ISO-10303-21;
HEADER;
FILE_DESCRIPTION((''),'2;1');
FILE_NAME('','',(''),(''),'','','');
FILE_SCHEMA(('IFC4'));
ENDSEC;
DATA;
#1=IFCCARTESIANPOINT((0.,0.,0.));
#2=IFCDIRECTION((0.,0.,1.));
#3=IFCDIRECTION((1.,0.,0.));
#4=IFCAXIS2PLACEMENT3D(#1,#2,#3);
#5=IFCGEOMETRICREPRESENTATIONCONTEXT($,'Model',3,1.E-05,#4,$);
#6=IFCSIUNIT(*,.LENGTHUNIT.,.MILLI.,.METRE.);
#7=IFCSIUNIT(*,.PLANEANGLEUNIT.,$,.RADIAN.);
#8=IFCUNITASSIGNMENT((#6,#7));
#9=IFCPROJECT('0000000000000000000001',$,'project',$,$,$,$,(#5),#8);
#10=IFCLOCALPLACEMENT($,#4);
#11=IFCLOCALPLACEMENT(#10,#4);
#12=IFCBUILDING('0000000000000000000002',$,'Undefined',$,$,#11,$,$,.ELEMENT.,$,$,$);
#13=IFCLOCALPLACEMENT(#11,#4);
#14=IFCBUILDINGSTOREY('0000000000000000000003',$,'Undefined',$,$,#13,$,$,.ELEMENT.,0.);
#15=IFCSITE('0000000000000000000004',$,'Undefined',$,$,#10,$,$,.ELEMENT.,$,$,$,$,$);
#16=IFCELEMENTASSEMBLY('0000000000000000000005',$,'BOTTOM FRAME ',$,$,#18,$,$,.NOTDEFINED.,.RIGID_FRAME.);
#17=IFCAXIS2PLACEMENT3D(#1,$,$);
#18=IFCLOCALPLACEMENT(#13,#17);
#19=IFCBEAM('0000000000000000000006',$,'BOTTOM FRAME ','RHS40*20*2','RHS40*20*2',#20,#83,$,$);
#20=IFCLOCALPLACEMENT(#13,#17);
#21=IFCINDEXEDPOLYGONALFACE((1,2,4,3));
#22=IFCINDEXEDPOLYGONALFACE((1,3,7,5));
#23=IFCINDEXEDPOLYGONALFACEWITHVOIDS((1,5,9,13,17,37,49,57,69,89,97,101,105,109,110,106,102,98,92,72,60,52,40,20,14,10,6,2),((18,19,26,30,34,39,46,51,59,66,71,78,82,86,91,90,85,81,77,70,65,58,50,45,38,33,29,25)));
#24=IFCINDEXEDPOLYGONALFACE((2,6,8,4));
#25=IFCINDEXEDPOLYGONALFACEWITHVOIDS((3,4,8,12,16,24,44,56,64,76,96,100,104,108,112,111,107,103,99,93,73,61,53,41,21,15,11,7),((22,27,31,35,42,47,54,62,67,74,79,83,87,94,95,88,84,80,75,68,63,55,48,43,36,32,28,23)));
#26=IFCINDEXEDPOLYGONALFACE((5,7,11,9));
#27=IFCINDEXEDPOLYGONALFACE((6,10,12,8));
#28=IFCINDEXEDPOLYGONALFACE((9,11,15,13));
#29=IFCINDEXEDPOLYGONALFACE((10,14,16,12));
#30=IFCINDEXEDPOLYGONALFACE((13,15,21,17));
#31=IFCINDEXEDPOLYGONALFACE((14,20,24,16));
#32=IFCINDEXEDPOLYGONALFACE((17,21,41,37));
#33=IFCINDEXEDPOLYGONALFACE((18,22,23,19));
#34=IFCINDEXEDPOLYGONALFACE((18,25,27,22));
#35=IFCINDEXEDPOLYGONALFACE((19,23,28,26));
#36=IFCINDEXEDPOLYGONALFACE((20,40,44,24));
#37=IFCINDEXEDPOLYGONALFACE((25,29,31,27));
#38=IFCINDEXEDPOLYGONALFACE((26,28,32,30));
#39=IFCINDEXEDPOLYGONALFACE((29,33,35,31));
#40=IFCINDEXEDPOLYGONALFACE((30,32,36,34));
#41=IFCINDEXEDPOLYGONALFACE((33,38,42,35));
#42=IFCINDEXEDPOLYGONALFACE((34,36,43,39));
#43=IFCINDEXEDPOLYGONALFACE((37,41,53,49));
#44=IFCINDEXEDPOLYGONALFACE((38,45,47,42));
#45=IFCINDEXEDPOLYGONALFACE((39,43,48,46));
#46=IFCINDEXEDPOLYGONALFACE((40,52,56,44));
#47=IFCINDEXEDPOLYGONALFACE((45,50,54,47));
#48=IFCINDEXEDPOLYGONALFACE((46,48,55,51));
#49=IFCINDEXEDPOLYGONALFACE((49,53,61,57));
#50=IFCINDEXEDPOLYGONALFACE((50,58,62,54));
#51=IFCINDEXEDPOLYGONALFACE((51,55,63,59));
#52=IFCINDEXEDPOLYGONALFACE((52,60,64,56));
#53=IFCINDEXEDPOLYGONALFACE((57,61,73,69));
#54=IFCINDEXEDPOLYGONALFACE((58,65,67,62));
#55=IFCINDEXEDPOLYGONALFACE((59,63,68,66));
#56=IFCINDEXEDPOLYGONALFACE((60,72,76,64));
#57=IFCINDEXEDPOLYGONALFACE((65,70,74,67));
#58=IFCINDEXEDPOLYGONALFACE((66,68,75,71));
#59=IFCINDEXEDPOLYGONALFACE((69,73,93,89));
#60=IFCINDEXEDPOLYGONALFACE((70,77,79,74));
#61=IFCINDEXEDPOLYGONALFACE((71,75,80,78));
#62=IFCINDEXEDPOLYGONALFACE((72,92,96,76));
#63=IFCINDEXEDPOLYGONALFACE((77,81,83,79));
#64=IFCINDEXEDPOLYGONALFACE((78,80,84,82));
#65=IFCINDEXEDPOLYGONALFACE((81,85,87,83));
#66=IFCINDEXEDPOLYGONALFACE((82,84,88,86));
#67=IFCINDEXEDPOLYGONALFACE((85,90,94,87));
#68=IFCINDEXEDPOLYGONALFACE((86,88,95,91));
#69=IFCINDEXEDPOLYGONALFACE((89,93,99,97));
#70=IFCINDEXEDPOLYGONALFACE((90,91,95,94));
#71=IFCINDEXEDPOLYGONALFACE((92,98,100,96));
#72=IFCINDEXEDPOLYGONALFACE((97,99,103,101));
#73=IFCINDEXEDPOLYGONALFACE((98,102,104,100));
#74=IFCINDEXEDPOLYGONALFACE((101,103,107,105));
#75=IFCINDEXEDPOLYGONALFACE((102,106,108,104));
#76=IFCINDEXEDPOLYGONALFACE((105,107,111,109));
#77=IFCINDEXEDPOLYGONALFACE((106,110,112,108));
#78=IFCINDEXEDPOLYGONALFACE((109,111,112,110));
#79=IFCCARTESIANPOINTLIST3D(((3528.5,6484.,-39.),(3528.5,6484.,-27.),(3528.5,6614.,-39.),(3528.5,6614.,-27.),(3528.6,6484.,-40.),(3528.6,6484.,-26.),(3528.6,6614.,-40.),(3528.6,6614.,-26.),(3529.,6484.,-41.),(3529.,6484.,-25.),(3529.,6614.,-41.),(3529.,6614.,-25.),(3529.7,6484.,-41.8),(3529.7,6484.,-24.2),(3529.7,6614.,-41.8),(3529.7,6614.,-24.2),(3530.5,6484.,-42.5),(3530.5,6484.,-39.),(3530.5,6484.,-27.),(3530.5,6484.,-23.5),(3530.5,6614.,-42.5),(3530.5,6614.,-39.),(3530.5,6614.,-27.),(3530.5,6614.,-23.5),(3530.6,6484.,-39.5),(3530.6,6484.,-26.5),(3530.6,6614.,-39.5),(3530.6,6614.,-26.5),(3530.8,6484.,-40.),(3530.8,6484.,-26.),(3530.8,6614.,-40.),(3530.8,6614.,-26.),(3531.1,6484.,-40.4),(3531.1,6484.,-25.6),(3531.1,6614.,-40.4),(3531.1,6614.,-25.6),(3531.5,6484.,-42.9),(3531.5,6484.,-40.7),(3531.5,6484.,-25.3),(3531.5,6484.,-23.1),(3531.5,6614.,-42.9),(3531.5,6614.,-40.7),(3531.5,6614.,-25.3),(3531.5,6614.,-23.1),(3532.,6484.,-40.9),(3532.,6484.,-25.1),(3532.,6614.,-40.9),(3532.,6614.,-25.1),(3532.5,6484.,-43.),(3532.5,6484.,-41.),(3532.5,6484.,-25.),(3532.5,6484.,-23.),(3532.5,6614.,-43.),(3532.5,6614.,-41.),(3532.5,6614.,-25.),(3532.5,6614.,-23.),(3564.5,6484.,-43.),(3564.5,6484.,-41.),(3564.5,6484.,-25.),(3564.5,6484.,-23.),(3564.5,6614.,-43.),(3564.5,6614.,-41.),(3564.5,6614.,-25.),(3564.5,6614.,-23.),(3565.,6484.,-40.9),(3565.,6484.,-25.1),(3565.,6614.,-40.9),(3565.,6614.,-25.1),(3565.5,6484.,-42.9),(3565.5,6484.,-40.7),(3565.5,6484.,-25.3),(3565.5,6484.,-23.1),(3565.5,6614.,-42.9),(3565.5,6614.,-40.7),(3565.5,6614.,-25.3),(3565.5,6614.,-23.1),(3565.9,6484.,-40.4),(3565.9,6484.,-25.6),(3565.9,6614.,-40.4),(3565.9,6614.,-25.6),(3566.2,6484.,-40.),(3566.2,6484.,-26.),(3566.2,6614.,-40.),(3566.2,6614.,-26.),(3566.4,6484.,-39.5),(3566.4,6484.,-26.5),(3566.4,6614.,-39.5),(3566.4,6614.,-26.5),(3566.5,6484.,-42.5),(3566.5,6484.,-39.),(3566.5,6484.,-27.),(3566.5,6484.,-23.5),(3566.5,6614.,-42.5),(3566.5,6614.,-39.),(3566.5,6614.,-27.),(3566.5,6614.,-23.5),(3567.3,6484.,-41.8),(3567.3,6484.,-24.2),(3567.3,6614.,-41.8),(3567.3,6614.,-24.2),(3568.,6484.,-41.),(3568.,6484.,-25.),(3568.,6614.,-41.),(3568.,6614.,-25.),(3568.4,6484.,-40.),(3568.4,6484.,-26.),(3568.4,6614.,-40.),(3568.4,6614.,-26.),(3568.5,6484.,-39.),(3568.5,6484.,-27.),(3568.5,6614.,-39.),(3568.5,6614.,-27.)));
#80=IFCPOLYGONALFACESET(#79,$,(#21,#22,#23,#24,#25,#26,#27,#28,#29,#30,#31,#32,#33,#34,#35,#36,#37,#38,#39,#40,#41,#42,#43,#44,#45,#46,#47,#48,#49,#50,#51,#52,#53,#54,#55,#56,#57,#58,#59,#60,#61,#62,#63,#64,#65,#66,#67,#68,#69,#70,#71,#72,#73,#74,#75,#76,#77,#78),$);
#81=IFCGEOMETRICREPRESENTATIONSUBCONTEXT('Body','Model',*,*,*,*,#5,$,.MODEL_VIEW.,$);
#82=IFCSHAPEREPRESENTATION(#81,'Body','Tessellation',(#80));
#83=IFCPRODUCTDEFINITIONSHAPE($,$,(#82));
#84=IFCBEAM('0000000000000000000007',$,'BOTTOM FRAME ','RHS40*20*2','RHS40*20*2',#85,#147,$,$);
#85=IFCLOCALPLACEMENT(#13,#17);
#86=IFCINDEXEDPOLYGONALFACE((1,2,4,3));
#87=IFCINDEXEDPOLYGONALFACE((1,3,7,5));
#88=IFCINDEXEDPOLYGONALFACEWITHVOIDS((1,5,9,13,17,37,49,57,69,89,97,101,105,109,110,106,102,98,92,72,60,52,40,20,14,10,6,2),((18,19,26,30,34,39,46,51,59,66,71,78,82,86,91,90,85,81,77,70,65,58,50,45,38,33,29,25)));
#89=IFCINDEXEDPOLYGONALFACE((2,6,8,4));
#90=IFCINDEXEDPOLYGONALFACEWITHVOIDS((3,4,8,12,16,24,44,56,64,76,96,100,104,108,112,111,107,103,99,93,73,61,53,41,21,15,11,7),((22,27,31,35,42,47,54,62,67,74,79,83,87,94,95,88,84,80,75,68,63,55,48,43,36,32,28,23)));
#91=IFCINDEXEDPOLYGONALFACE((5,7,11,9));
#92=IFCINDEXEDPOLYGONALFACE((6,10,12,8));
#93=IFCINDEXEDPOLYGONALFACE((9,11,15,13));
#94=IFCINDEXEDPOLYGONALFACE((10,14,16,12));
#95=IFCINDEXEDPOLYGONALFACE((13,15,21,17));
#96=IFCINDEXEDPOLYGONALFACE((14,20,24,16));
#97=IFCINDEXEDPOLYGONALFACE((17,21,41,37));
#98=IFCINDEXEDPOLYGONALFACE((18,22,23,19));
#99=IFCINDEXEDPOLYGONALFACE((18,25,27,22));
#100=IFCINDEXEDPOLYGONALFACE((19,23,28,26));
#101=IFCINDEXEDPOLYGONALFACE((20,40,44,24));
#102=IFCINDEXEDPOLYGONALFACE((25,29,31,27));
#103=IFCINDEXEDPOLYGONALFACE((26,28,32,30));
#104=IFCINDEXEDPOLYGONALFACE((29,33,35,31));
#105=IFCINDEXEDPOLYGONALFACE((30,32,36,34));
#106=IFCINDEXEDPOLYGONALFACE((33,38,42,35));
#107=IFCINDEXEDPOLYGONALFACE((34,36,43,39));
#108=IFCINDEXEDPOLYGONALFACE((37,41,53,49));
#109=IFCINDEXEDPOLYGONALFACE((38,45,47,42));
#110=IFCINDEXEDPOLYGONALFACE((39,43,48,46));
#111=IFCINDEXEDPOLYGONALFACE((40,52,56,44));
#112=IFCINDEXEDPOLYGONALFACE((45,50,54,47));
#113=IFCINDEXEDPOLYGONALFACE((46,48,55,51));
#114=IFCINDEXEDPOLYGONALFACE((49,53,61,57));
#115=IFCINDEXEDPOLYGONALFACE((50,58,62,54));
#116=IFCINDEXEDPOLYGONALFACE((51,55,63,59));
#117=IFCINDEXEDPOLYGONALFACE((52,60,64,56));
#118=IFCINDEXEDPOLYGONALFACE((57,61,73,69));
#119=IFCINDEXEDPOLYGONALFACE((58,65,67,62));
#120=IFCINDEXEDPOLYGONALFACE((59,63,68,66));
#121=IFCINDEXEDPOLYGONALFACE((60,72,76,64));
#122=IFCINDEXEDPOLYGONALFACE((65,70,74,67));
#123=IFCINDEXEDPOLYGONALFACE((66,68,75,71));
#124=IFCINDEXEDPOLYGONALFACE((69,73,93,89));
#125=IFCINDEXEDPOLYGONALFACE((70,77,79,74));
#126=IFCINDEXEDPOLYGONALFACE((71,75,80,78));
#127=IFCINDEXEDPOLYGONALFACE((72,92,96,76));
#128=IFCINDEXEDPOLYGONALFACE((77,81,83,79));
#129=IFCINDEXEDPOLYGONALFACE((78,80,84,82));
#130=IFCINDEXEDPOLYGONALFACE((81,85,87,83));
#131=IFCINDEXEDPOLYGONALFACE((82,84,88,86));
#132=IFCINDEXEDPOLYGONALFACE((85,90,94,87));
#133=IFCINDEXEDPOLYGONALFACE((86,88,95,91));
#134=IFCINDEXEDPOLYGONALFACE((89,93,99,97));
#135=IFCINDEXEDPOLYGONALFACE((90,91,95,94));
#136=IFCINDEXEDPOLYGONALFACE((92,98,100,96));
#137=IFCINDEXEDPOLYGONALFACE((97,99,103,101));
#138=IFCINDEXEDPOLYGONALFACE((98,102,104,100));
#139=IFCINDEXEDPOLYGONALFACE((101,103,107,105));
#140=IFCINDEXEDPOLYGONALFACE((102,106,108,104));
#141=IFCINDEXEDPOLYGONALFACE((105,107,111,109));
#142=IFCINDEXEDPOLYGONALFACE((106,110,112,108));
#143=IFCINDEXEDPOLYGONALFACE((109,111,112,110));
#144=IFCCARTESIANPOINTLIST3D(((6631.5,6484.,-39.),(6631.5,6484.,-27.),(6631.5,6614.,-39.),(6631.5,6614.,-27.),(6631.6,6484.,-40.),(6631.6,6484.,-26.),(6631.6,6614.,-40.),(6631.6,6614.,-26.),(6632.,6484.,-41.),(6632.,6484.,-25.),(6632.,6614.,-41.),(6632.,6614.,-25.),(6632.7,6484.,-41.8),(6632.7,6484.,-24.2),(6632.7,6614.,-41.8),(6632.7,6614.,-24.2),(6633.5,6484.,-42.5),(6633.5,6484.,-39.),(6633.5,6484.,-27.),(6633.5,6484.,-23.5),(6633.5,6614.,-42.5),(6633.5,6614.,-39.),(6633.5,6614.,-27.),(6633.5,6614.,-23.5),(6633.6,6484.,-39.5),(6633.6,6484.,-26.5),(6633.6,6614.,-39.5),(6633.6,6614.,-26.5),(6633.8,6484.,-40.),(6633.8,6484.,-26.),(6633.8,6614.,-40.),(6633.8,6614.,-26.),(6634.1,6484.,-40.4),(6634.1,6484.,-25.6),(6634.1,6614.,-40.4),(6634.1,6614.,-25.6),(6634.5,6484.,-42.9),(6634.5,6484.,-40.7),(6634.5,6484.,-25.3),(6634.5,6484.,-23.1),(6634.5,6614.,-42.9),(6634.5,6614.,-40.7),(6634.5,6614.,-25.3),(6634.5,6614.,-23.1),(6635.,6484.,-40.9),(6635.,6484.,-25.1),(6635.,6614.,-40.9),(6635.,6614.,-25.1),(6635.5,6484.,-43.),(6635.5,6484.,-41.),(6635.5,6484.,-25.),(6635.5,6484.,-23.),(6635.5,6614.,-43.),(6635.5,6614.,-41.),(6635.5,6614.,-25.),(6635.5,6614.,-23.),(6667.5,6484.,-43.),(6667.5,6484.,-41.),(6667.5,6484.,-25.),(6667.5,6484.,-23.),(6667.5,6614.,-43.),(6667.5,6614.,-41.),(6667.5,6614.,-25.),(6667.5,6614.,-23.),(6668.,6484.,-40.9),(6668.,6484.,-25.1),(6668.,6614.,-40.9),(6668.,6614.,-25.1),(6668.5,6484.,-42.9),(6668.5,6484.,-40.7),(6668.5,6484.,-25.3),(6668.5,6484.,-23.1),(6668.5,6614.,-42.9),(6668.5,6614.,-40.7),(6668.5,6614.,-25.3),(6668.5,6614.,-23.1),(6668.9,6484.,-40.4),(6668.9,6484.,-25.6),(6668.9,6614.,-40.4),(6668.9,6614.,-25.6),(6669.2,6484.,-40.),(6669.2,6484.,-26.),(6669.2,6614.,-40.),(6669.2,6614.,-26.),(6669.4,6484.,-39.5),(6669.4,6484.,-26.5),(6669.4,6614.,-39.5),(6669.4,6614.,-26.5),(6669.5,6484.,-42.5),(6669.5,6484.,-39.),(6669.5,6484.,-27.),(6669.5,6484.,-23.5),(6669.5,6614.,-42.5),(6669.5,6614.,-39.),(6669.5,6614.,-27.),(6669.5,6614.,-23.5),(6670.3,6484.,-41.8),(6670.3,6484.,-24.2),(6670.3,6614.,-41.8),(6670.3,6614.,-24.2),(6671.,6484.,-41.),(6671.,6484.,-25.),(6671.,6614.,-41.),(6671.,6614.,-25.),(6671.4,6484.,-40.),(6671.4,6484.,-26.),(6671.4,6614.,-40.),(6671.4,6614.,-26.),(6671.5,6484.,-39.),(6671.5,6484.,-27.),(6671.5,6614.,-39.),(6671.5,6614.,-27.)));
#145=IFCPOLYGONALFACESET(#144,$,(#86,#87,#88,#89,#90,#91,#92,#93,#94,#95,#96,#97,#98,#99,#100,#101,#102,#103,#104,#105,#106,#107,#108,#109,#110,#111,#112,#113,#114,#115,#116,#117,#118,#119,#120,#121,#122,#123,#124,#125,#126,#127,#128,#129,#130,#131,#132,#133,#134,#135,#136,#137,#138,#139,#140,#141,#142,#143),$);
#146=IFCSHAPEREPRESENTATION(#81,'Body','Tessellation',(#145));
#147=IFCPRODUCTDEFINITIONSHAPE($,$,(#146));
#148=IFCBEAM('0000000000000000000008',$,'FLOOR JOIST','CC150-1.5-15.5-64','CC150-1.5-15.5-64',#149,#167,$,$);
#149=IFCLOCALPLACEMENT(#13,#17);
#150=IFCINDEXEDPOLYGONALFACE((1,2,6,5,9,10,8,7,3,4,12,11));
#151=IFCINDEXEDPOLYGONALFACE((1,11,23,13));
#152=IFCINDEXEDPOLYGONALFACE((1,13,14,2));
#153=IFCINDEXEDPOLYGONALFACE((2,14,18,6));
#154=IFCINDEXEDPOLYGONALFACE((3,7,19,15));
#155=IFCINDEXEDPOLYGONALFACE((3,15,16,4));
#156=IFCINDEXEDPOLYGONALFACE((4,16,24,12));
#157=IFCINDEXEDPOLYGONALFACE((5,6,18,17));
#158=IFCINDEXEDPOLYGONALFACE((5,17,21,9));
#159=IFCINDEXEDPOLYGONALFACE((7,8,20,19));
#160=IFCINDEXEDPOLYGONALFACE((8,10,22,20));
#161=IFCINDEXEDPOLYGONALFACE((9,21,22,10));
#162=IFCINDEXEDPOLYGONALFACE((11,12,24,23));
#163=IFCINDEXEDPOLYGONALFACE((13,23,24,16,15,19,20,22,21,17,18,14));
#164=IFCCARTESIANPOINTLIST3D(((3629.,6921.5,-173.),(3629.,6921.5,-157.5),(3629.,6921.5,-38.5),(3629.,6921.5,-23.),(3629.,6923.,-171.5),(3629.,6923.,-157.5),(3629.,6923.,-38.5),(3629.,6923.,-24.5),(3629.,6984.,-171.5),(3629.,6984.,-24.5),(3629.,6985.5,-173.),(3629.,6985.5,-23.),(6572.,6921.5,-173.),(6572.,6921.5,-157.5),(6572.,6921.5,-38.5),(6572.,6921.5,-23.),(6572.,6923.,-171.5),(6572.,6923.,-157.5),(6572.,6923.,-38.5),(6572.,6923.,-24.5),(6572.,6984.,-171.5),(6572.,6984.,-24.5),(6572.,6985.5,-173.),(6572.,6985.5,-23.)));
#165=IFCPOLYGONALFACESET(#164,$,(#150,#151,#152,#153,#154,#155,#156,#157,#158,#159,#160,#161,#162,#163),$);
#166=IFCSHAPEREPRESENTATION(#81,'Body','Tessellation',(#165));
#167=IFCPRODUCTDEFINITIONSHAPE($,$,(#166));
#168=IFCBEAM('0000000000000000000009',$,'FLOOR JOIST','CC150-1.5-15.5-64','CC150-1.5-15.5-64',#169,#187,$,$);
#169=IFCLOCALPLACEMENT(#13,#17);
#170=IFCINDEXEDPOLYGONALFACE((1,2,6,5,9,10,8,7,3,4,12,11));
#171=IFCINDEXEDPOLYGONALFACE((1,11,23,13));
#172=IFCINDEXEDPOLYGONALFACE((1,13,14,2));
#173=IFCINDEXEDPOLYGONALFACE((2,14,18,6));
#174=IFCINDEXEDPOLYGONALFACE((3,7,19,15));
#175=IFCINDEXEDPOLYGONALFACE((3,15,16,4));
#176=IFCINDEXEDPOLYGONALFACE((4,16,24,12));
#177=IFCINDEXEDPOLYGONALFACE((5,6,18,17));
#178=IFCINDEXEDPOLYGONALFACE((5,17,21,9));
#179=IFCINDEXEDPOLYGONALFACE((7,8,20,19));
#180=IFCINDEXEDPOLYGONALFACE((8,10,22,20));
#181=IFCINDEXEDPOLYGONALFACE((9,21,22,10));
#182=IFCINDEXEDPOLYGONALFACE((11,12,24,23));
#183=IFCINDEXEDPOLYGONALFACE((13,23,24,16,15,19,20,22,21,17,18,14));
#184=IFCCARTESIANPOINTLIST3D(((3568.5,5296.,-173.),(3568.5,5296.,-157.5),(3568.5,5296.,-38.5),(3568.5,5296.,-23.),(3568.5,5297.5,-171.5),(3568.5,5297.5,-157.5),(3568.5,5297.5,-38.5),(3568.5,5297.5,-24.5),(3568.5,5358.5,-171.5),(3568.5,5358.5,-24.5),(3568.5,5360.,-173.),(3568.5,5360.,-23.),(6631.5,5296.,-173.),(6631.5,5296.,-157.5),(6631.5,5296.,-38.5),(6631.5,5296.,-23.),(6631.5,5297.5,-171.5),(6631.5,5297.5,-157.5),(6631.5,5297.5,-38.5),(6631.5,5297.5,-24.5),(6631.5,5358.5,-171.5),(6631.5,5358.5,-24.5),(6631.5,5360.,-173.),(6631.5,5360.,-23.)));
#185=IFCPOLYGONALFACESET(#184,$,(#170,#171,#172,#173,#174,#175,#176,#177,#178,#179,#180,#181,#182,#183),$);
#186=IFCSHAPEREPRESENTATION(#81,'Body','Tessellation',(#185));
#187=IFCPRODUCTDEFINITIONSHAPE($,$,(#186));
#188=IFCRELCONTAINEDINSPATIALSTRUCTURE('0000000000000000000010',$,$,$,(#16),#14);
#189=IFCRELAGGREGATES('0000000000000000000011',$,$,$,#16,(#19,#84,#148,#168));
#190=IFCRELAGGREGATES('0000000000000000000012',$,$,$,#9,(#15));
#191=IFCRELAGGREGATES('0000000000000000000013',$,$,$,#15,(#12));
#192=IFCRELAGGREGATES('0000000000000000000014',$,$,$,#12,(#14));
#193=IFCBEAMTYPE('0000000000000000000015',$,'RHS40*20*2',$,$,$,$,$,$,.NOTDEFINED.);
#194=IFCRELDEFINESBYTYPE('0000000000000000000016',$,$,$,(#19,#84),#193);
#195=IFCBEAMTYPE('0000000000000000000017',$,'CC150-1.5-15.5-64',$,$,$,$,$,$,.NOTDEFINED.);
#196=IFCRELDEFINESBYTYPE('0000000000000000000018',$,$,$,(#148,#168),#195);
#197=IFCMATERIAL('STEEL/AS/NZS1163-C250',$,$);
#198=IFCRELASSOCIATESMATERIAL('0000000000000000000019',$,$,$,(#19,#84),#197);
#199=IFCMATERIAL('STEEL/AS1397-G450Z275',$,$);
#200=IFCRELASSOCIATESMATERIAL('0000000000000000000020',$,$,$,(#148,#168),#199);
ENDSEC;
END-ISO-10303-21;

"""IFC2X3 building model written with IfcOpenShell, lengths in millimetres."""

from ifc_helpers import new_model, si_unit, frame, origin_with_axes, origin_2d_with_axis, place, context, subcontext, project, spatial, hollow_rectangle, c_section, extrude, material, type_object, element, aggregate, save


model = new_model("IFC2X3")

# Units and contexts
model_context = context("Model", 3, precision=1e-05, world=origin_with_axes())
body_context = subcontext(model_context, "Body", "Model", "MODEL_VIEW")
ifc_project = project(units=[si_unit("LENGTHUNIT", "METRE", prefix="MILLI"), si_unit("PLANEANGLEUNIT", "RADIAN")], contexts=[model_context])

# Site, building, storey
site_placement = place(None, origin_with_axes())
site = spatial("IfcSite", under=ifc_project, at=site_placement, Name="Undefined", CompositionType="ELEMENT")
building_placement = place(site_placement, origin_with_axes())
building = spatial("IfcBuilding", under=site, at=building_placement, Name="Undefined", CompositionType="ELEMENT")
storey_placement = place(building_placement, origin_with_axes())
storey = spatial("IfcBuildingStorey", under=building, at=storey_placement, Name="Undefined", CompositionType="ELEMENT", Elevation=0.0)

# Element assembly, beams
assembly_1_placement = place(storey_placement, origin_with_axes())
assembly_1 = element("IfcElementAssembly", 1, at=assembly_1_placement, inside=storey, Name="BOTTOM FRAME ", AssemblyPlace="NOTDEFINED", PredefinedType="RIGID_FRAME")
ifc_material_1 = material(Name="STEEL/AS1397-G450Z275")
ifc_material_2 = material(Name="STEEL/AS/NZS1163-C250")
beam_type_1 = type_object("IfcBeamType", Name="RHS40*20*2", PredefinedType="NOTDEFINED")
beam_1_placement = place(assembly_1_placement, frame((3548.5, 6614.0, -33.0), z_axis=(1.0, 0.0, 0.0), x_axis=(0.0, -1.0, 0.0)))
beam_1 = element("IfcBeam", 2, at=beam_1_placement, type_object=beam_type_1, material=ifc_material_2, Name="BOTTOM FRAME ", Description="RHS40*20*2", ObjectType="RHS40*20*2", context=body_context, shape_type="SweptSolid", body=[
    extrude(hollow_rectangle(XDim=20.0, YDim=40.0, WallThickness=2.0, InnerFilletRadius=2.0, OuterFilletRadius=4.0, at=origin_2d_with_axis()), frame((130.0, 0.0, 0.0), z_axis=(-1.0, 0.0, 0.0), x_axis=(0.0, -1.0, 0.0)), (0.0, 0.0, 1.0), 130.0),
])
beam_2_placement = place(assembly_1_placement, frame((6651.5, 6614.0, -33.0), z_axis=(-1.0, 0.0, 0.0), x_axis=(0.0, -1.0, 0.0)))
beam_2 = element("IfcBeam", 3, at=beam_2_placement, type_object=beam_type_1, material=ifc_material_2, Name="BOTTOM FRAME ", Description="RHS40*20*2", ObjectType="RHS40*20*2", context=body_context, shape_type="SweptSolid", body=[
    extrude(hollow_rectangle(XDim=20.0, YDim=40.0, WallThickness=2.0, InnerFilletRadius=2.0, OuterFilletRadius=4.0, at=origin_2d_with_axis()), frame((130.0, 0.0, 0.0), z_axis=(-1.0, 0.0, 0.0), x_axis=(0.0, -1.0, 0.0)), (0.0, 0.0, 1.0), 130.0),
])
beam_type_2 = type_object("IfcBeamType", Name="CC150-1.5-15.5-64", PredefinedType="NOTDEFINED")
beam_3_placement = place(assembly_1_placement, frame((3629.0, 6953.5, -98.0), z_axis=(0.0, 0.0, 1.0), x_axis=(1.0, 0.0, 0.0)))
beam_3 = element("IfcBeam", 4, at=beam_3_placement, type_object=beam_type_2, material=ifc_material_1, Name="FLOOR JOIST", Description="CC150-1.5-15.5-64", ObjectType="CC150-1.5-15.5-64", context=body_context, shape_type="SweptSolid", body=[
    extrude(c_section(Depth=150.0, Width=64.0, WallThickness=1.5, Girth=15.5, at=origin_2d_with_axis()), frame((2943.0, 0.0, 0.0), z_axis=(-1.0, 0.0, 0.0), x_axis=(0.0, -1.0, 0.0)), (0.0, 0.0, 1.0), 2943.0),
])
beam_4_placement = place(assembly_1_placement, frame((3568.5, 5328.0, -98.0), z_axis=(0.0, 0.0, 1.0), x_axis=(1.0, 0.0, 0.0)))
beam_4 = element("IfcBeam", 5, at=beam_4_placement, type_object=beam_type_2, material=ifc_material_1, Name="FLOOR JOIST", Description="CC150-1.5-15.5-64", ObjectType="CC150-1.5-15.5-64", context=body_context, shape_type="SweptSolid", body=[
    extrude(c_section(Depth=150.0, Width=64.0, WallThickness=1.5, Girth=15.5, at=origin_2d_with_axis()), frame((3063.0, 0.0, 0.0), z_axis=(-1.0, 0.0, 0.0), x_axis=(0.0, -1.0, 0.0)), (0.0, 0.0, 1.0), 3063.0),
])

aggregate(assembly_1, [beam_1, beam_2, beam_3, beam_4])

save(model, "model.ifc")
